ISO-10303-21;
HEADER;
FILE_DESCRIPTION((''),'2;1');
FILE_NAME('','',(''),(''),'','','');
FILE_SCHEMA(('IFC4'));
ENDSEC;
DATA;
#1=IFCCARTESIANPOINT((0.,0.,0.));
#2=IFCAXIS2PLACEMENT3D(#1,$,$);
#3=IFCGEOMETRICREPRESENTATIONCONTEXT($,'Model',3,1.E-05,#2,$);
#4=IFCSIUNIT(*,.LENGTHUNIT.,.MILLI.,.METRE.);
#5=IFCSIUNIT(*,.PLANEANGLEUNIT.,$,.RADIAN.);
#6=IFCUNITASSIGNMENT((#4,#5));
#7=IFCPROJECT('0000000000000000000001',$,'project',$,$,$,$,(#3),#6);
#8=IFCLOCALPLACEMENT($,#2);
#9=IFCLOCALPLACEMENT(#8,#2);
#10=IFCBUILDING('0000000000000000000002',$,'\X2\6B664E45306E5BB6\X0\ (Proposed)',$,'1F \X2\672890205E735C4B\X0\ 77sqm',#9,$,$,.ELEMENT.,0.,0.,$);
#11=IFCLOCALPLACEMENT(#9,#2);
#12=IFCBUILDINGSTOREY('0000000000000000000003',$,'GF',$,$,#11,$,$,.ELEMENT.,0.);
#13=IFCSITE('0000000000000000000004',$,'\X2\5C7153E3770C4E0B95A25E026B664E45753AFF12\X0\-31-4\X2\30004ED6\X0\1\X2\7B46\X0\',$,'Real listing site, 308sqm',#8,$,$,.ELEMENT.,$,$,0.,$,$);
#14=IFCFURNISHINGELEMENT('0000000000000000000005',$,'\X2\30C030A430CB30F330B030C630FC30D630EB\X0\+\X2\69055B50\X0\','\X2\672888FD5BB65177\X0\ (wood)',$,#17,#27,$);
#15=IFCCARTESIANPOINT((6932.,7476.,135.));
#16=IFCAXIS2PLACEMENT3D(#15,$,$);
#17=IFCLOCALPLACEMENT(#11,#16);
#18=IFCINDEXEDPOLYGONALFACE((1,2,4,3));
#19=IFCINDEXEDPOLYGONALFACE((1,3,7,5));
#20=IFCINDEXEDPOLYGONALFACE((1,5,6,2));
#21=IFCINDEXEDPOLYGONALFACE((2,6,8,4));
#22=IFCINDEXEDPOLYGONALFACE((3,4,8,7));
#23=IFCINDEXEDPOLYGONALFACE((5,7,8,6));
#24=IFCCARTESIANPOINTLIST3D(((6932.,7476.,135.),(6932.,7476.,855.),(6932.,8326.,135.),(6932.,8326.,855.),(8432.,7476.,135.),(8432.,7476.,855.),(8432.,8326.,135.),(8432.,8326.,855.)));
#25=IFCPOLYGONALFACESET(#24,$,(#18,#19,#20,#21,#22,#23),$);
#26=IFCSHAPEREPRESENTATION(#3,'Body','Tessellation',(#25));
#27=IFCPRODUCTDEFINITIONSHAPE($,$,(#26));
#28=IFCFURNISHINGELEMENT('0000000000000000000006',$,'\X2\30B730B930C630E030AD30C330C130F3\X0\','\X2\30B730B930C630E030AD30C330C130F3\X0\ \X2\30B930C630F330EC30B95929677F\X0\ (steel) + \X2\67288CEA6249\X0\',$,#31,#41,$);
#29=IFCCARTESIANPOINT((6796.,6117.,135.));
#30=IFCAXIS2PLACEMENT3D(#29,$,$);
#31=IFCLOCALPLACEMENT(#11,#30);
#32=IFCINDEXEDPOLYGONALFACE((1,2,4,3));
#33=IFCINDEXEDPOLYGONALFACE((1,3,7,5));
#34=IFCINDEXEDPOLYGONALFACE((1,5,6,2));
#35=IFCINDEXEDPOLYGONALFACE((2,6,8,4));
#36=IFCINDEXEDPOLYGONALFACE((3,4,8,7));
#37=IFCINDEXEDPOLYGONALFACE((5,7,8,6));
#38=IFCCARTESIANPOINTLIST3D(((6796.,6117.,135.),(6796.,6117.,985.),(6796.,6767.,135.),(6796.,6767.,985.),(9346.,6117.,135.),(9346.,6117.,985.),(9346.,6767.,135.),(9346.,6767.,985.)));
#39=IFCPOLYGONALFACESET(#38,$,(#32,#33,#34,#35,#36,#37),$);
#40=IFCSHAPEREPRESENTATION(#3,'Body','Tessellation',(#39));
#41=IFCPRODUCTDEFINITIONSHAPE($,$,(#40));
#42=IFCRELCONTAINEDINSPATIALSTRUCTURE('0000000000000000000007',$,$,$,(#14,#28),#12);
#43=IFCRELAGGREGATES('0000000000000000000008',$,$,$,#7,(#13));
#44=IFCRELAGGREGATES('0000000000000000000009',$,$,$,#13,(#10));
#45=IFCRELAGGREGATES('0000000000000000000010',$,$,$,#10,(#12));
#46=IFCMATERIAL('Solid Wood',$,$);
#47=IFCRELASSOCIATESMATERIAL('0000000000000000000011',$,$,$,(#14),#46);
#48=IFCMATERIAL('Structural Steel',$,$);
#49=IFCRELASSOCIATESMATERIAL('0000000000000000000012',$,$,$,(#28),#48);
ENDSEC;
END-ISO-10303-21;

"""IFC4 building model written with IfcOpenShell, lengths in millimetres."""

from ifc_helpers import new_model, si_unit, frame, frame_2d, origin, place, context, project, spatial, rectangle, extrude, material, element, save


model = new_model("IFC4")

# Units and contexts
model_context = context("Model", 3, precision=1e-05, world=origin())
ifc_project = project(units=[si_unit("LENGTHUNIT", "METRE", prefix="MILLI"), si_unit("PLANEANGLEUNIT", "RADIAN")], contexts=[model_context])

# Site, building, storey
site_placement = place(None, origin())
site = spatial("IfcSite", under=ifc_project, at=site_placement, Name="山口県下関市武久町２-31-4　他1筆", ObjectType="Real listing site, 308sqm", CompositionType="ELEMENT", RefElevation=0.0)
building_placement = place(site_placement, origin())
building = spatial("IfcBuilding", under=site, at=building_placement, Name="武久の家 (Proposed)", ObjectType="1F 木造平屋 77sqm", CompositionType="ELEMENT", ElevationOfRefHeight=0.0, ElevationOfTerrain=0.0)
storey_placement = place(building_placement, origin())
storey = spatial("IfcBuildingStorey", under=building, at=storey_placement, Name="GF", CompositionType="ELEMENT", Elevation=0.0)

# Shared definitions
ifc_material_1 = material(Name="Solid Wood")

# Shared definitions
ifc_material_2 = material(Name="Structural Steel")

# Furnishing elements
furnishing_1_placement = place(storey_placement, frame((6932.0, 7476.0, 135.0)))
element("IfcFurnishingElement", 1, at=furnishing_1_placement, inside=storey, material=ifc_material_1, Name="ダイニングテーブル+椅子", Description="木製家具 (wood)", context=model_context, shape_type="SweptSolid", body=[
    extrude(rectangle(XDim=1500.0, YDim=850.0, at=frame_2d((750.0, 425.0))), frame((6932.0, 7476.0, 135.0)), (0.0, 0.0, 1.0), 720.0),
])
furnishing_2_placement = place(storey_placement, frame((6796.0, 6117.0, 135.0)))
element("IfcFurnishingElement", 2, at=furnishing_2_placement, inside=storey, material=ifc_material_2, Name="システムキッチン", Description="システムキッチン ステンレス天板 (steel) + 木質扉", context=model_context, shape_type="SweptSolid", body=[
    extrude(rectangle(XDim=2550.0, YDim=650.0, at=frame_2d((1275.0, 325.0))), frame((6796.0, 6117.0, 135.0)), (0.0, 0.0, 1.0), 850.0),
])

save(model, "model.ifc")
